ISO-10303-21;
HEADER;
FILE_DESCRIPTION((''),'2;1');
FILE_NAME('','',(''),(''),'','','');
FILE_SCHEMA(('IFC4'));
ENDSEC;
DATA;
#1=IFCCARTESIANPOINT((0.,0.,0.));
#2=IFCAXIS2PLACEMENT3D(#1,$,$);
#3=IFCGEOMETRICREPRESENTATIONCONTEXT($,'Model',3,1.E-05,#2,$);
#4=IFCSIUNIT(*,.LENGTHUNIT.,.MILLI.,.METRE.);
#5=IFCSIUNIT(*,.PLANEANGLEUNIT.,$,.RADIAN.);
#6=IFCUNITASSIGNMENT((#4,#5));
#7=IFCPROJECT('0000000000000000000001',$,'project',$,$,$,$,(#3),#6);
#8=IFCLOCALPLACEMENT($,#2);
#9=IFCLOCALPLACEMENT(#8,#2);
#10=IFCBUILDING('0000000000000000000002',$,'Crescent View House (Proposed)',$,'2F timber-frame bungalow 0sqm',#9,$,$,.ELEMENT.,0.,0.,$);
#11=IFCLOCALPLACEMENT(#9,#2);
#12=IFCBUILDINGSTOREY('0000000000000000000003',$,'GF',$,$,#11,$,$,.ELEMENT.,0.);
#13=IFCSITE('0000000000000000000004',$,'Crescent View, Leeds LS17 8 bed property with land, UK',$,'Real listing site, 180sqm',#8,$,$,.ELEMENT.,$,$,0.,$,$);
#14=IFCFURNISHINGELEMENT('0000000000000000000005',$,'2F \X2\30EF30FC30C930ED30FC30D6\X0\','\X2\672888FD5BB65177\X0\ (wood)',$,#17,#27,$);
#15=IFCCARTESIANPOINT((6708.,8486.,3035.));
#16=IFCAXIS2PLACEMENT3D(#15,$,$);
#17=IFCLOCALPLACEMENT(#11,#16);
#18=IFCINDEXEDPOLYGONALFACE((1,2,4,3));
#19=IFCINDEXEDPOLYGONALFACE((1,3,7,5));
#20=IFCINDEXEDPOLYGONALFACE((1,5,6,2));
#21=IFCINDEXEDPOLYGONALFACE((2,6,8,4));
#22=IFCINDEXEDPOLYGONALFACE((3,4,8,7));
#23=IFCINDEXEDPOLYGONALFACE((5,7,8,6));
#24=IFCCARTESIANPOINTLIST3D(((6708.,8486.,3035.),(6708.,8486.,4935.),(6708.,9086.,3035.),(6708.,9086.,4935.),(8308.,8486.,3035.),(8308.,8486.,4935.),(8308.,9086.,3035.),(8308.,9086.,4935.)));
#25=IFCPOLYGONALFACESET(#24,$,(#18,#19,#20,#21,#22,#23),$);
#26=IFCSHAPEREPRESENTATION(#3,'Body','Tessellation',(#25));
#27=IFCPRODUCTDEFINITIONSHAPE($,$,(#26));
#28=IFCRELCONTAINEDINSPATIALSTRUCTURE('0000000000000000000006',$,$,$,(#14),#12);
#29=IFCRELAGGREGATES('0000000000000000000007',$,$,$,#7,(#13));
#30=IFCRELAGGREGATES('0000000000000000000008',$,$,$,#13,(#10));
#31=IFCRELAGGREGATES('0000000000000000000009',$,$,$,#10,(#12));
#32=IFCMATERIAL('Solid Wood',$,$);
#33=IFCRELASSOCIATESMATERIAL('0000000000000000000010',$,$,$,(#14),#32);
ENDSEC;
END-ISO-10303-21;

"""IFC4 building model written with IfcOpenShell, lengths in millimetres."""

from ifc_helpers import new_model, si_unit, frame, frame_2d, origin, place, context, project, spatial, rectangle, extrude, material, element, save


model = new_model("IFC4")

# Units and contexts
model_context = context("Model", 3, precision=1e-05, world=origin())
ifc_project = project(units=[si_unit("LENGTHUNIT", "METRE", prefix="MILLI"), si_unit("PLANEANGLEUNIT", "RADIAN")], contexts=[model_context])

# Site, building, storey
site_placement = place(None, origin())
site = spatial("IfcSite", under=ifc_project, at=site_placement, Name="Crescent View, Leeds LS17 8 bed property with land, UK", ObjectType="Real listing site, 180sqm", CompositionType="ELEMENT", RefElevation=0.0)
building_placement = place(site_placement, origin())
building = spatial("IfcBuilding", under=site, at=building_placement, Name="Crescent View House (Proposed)", ObjectType="2F timber-frame bungalow 0sqm", CompositionType="ELEMENT", ElevationOfRefHeight=0.0, ElevationOfTerrain=0.0)
storey_placement = place(building_placement, origin())
storey = spatial("IfcBuildingStorey", under=building, at=storey_placement, Name="GF", CompositionType="ELEMENT", Elevation=0.0)

# Shared definitions
ifc_material_1 = material(Name="Solid Wood")

# Furnishing element
furnishing_1_placement = place(storey_placement, frame((6708.0, 8486.0, 3035.0)))
element("IfcFurnishingElement", 1, at=furnishing_1_placement, inside=storey, material=ifc_material_1, Name="2F ワードローブ", Description="木製家具 (wood)", context=model_context, shape_type="SweptSolid", body=[
    extrude(rectangle(XDim=1600.0, YDim=600.0, at=frame_2d((800.0, 300.0))), frame((6708.0, 8486.0, 3035.0)), (0.0, 0.0, 1.0), 1900.0),
])

save(model, "model.ifc")
